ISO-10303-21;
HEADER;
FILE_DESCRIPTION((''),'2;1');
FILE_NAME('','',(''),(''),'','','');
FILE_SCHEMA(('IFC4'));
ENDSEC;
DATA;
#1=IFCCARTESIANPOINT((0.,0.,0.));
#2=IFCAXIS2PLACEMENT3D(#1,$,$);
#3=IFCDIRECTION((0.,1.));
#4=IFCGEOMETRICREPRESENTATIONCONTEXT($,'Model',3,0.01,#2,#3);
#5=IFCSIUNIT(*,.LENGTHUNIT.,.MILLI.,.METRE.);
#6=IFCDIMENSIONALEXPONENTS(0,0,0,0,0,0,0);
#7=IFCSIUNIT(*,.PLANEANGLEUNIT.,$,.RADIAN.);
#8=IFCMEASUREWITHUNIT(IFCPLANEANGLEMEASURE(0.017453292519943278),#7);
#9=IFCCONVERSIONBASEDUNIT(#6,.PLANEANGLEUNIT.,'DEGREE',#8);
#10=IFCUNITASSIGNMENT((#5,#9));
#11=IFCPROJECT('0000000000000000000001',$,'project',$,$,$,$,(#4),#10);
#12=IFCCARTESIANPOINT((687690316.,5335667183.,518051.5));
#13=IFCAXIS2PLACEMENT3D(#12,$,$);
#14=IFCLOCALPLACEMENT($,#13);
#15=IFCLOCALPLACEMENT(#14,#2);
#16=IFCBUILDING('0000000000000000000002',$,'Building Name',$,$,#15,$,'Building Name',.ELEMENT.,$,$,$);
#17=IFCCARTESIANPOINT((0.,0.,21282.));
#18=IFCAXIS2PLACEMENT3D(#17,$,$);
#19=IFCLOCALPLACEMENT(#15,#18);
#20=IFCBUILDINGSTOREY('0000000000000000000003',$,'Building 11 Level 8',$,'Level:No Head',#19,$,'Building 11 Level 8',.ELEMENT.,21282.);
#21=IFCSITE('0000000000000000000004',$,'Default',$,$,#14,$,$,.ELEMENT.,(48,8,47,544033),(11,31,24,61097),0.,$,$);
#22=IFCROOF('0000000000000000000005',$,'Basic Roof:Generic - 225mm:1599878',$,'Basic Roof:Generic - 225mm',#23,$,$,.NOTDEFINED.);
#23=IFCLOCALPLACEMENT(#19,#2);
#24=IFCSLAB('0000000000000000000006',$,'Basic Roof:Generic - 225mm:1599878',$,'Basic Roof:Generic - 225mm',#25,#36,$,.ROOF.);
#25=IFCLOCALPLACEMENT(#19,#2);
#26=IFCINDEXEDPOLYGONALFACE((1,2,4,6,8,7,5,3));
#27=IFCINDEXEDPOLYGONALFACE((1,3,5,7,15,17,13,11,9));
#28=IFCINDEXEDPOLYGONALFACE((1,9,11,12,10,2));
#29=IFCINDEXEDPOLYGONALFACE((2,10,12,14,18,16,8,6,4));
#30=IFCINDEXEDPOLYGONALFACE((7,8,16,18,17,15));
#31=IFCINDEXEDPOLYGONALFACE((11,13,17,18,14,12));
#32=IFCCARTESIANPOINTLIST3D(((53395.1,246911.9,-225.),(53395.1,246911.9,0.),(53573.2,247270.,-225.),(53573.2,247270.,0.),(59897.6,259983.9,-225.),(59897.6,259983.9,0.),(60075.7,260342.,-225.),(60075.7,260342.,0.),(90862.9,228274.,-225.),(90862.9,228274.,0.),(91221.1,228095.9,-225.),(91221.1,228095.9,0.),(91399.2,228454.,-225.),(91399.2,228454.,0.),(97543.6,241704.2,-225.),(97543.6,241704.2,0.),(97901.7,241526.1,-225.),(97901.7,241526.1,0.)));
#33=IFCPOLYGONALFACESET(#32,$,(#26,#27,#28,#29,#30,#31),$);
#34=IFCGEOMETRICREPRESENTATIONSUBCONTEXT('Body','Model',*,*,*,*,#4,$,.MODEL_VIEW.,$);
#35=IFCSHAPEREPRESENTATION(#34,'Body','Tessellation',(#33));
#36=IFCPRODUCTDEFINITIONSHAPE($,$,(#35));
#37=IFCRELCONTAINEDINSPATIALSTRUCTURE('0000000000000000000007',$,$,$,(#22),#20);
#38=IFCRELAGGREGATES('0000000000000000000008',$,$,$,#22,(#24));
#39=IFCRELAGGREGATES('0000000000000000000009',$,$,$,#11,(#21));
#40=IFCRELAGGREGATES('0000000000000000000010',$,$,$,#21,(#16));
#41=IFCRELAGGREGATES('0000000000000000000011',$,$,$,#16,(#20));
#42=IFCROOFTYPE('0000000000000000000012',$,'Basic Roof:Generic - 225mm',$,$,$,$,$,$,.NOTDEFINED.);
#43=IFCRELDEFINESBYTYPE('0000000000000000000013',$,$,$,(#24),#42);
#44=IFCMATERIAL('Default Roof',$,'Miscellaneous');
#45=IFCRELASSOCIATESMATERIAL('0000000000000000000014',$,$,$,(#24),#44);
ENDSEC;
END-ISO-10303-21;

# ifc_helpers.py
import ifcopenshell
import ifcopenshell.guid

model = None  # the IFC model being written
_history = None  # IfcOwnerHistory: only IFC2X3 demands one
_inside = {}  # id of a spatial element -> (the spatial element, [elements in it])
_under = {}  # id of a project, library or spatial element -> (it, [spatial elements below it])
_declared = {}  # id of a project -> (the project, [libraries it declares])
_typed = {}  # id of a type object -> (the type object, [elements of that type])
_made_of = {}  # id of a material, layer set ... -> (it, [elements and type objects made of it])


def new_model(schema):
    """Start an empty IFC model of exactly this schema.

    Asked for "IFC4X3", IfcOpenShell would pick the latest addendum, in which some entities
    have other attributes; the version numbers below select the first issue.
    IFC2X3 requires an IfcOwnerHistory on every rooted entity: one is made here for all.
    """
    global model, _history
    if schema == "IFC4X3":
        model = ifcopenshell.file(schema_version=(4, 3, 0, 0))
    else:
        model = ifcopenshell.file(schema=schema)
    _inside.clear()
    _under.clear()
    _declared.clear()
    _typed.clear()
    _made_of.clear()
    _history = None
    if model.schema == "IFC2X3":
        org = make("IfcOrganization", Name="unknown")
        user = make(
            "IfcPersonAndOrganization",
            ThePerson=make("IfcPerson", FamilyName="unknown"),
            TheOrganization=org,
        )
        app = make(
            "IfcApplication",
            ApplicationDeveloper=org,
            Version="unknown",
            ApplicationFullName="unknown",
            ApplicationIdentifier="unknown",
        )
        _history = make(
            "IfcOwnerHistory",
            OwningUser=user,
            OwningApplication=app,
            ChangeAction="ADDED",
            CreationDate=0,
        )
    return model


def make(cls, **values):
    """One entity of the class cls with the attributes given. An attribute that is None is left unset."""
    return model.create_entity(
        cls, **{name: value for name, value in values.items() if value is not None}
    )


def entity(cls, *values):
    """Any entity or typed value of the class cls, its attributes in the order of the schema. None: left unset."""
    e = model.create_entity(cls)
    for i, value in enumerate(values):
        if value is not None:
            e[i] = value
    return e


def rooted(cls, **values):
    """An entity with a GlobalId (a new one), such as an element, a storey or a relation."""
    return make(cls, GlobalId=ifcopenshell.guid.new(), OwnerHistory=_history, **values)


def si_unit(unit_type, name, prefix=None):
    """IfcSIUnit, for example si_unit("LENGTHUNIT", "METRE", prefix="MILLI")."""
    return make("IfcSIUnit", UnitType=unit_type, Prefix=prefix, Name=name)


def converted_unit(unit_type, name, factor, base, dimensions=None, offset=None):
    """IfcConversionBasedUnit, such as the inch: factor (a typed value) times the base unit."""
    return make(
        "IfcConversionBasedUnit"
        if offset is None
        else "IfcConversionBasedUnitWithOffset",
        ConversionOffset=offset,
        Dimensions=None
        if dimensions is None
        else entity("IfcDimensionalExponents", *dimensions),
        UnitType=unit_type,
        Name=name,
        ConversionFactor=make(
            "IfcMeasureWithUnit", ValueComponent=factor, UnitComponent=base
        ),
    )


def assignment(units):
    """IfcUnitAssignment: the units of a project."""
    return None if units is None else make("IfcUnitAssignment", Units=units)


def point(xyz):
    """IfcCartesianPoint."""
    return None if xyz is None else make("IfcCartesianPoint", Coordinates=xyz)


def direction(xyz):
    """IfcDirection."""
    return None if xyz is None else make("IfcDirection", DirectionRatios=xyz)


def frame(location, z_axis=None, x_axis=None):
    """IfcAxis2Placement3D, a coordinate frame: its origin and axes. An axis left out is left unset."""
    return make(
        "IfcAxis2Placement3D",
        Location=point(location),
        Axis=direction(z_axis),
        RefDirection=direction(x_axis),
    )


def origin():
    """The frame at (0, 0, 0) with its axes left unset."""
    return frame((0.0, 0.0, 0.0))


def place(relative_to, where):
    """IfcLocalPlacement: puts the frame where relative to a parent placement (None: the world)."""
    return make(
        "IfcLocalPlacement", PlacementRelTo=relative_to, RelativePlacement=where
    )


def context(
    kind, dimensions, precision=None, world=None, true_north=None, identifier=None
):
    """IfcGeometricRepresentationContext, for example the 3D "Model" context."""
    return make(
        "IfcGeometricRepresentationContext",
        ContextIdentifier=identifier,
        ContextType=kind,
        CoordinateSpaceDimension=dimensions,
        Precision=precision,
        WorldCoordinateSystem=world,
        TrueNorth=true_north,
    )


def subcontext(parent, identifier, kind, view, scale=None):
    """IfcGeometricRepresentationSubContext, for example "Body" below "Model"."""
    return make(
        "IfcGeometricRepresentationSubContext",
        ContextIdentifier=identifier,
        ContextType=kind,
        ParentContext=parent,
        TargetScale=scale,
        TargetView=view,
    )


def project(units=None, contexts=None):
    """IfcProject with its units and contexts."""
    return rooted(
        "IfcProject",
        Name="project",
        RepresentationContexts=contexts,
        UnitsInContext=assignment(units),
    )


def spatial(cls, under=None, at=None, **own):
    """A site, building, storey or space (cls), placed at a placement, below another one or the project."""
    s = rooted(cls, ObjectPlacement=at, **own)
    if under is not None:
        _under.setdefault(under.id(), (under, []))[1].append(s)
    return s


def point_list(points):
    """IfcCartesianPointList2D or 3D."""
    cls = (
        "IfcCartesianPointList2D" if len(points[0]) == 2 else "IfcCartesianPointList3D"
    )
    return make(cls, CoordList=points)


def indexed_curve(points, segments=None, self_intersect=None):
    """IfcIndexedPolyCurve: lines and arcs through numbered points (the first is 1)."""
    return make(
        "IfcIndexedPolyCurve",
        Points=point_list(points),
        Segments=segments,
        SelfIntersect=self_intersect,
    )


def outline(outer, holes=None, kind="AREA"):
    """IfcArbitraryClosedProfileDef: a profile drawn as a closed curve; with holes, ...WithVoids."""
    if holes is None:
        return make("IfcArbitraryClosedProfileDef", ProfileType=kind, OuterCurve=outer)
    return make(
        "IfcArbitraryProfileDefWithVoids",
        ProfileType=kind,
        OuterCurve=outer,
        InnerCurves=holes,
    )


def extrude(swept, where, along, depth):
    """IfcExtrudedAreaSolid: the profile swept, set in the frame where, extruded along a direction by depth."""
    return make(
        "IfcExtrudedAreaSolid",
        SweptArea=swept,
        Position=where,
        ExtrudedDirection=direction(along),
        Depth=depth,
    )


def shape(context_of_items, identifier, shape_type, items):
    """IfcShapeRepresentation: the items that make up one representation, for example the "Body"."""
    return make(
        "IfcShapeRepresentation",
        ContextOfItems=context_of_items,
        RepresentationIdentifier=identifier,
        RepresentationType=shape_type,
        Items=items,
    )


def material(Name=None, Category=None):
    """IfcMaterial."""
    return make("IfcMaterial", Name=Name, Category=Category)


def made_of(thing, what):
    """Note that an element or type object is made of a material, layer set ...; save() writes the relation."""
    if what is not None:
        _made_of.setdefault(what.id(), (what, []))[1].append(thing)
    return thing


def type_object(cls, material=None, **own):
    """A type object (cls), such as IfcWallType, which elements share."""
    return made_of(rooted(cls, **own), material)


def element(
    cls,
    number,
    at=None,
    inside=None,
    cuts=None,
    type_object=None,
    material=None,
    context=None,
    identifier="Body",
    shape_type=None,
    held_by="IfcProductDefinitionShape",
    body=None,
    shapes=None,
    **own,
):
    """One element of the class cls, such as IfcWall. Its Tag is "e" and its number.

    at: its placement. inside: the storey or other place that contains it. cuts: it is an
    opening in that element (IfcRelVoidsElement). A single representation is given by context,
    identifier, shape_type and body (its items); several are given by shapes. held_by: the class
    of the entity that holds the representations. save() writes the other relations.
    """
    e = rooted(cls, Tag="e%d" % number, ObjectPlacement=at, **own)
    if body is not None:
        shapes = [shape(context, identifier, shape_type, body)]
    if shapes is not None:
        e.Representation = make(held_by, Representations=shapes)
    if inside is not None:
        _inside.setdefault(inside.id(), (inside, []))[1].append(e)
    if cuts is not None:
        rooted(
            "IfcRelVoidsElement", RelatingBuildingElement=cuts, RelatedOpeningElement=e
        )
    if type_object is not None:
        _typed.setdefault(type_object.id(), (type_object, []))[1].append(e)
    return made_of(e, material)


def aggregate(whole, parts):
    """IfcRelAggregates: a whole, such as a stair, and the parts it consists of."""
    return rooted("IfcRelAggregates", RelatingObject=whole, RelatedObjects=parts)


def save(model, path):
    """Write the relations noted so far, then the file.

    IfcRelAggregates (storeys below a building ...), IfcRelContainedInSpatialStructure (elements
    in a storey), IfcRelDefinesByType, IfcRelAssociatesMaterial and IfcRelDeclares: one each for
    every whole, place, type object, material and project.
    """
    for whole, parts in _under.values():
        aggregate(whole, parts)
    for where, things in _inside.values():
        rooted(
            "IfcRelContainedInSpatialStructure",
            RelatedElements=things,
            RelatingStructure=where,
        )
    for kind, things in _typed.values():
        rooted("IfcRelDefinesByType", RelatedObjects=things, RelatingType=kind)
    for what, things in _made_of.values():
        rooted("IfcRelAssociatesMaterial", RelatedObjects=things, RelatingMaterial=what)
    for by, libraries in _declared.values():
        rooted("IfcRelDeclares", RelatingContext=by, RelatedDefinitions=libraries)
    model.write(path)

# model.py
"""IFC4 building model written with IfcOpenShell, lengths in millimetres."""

from ifc_helpers import new_model, entity, si_unit, converted_unit, direction, frame, origin, place, context, subcontext, project, spatial, indexed_curve, outline, extrude, material, type_object, element, aggregate, save


model = new_model("IFC4")

# Units and contexts
model_context = context("Model", 3, precision=0.01, world=origin(), true_north=direction((0.0, 1.0)))
body_context = subcontext(model_context, "Body", "Model", "MODEL_VIEW")
ifc_project = project(units=[si_unit("LENGTHUNIT", "METRE", prefix="MILLI"), converted_unit("PLANEANGLEUNIT", "DEGREE", entity("IfcPlaneAngleMeasure", 0.017453292519943278), si_unit("PLANEANGLEUNIT", "RADIAN"), dimensions=[0, 0, 0, 0, 0, 0, 0])], contexts=[model_context])

# Site, building, storey
site_placement = place(None, frame((687690316.0, 5335667183.0, 518051.5)))
site = spatial("IfcSite", under=ifc_project, at=site_placement, Name="Default", CompositionType="ELEMENT", RefLatitude=(48, 8, 47, 544033), RefLongitude=(11, 31, 24, 61097), RefElevation=0.0)
building_placement = place(site_placement, origin())
building = spatial("IfcBuilding", under=site, at=building_placement, Name="Building Name", LongName="Building Name", CompositionType="ELEMENT")
storey_placement = place(building_placement, frame((0.0, 0.0, 21282.0)))
storey = spatial("IfcBuildingStorey", under=building, at=storey_placement, Name="Building 11 Level 8", ObjectType="Level:No Head", LongName="Building 11 Level 8", CompositionType="ELEMENT", Elevation=21282.0)

# Roof, slab
roof_placement = place(storey_placement, frame((53395.1, 228095.9, -225.0)))
roof = element("IfcRoof", 1, at=roof_placement, inside=storey, Name="Basic Roof:Generic - 225mm:1599878", ObjectType="Basic Roof:Generic - 225mm", PredefinedType="NOTDEFINED")
ifc_material = material(Name="Default Roof", Category="Miscellaneous")
roof_type = type_object("IfcRoofType", Name="Basic Roof:Generic - 225mm", PredefinedType="NOTDEFINED")
slab_placement = place(roof_placement, origin())
slab = element("IfcSlab", 2, at=slab_placement, type_object=roof_type, material=ifc_material, Name="Basic Roof:Generic - 225mm:1599878", ObjectType="Basic Roof:Generic - 225mm", PredefinedType="ROOF", context=body_context, shape_type="SweptSolid", body=[
    extrude(outline(indexed_curve([(15572.7, -16123.1), (15750.8, -15764.9), (22253.3, -2692.9), (21895.2, -2514.8), (-15572.7, 16123.1), (-15750.8, 15764.9), (-22075.2, 3051.1), (-22253.3, 2692.9), (15214.5, -15944.9), (15572.7, -16123.1)], self_intersect=False)), frame((22253.3, 16123.1, 0.0)), (0.0, 0.0, 1.0), 225.0),
])
aggregate(roof, [slab])

save(model, "model.ifc")
